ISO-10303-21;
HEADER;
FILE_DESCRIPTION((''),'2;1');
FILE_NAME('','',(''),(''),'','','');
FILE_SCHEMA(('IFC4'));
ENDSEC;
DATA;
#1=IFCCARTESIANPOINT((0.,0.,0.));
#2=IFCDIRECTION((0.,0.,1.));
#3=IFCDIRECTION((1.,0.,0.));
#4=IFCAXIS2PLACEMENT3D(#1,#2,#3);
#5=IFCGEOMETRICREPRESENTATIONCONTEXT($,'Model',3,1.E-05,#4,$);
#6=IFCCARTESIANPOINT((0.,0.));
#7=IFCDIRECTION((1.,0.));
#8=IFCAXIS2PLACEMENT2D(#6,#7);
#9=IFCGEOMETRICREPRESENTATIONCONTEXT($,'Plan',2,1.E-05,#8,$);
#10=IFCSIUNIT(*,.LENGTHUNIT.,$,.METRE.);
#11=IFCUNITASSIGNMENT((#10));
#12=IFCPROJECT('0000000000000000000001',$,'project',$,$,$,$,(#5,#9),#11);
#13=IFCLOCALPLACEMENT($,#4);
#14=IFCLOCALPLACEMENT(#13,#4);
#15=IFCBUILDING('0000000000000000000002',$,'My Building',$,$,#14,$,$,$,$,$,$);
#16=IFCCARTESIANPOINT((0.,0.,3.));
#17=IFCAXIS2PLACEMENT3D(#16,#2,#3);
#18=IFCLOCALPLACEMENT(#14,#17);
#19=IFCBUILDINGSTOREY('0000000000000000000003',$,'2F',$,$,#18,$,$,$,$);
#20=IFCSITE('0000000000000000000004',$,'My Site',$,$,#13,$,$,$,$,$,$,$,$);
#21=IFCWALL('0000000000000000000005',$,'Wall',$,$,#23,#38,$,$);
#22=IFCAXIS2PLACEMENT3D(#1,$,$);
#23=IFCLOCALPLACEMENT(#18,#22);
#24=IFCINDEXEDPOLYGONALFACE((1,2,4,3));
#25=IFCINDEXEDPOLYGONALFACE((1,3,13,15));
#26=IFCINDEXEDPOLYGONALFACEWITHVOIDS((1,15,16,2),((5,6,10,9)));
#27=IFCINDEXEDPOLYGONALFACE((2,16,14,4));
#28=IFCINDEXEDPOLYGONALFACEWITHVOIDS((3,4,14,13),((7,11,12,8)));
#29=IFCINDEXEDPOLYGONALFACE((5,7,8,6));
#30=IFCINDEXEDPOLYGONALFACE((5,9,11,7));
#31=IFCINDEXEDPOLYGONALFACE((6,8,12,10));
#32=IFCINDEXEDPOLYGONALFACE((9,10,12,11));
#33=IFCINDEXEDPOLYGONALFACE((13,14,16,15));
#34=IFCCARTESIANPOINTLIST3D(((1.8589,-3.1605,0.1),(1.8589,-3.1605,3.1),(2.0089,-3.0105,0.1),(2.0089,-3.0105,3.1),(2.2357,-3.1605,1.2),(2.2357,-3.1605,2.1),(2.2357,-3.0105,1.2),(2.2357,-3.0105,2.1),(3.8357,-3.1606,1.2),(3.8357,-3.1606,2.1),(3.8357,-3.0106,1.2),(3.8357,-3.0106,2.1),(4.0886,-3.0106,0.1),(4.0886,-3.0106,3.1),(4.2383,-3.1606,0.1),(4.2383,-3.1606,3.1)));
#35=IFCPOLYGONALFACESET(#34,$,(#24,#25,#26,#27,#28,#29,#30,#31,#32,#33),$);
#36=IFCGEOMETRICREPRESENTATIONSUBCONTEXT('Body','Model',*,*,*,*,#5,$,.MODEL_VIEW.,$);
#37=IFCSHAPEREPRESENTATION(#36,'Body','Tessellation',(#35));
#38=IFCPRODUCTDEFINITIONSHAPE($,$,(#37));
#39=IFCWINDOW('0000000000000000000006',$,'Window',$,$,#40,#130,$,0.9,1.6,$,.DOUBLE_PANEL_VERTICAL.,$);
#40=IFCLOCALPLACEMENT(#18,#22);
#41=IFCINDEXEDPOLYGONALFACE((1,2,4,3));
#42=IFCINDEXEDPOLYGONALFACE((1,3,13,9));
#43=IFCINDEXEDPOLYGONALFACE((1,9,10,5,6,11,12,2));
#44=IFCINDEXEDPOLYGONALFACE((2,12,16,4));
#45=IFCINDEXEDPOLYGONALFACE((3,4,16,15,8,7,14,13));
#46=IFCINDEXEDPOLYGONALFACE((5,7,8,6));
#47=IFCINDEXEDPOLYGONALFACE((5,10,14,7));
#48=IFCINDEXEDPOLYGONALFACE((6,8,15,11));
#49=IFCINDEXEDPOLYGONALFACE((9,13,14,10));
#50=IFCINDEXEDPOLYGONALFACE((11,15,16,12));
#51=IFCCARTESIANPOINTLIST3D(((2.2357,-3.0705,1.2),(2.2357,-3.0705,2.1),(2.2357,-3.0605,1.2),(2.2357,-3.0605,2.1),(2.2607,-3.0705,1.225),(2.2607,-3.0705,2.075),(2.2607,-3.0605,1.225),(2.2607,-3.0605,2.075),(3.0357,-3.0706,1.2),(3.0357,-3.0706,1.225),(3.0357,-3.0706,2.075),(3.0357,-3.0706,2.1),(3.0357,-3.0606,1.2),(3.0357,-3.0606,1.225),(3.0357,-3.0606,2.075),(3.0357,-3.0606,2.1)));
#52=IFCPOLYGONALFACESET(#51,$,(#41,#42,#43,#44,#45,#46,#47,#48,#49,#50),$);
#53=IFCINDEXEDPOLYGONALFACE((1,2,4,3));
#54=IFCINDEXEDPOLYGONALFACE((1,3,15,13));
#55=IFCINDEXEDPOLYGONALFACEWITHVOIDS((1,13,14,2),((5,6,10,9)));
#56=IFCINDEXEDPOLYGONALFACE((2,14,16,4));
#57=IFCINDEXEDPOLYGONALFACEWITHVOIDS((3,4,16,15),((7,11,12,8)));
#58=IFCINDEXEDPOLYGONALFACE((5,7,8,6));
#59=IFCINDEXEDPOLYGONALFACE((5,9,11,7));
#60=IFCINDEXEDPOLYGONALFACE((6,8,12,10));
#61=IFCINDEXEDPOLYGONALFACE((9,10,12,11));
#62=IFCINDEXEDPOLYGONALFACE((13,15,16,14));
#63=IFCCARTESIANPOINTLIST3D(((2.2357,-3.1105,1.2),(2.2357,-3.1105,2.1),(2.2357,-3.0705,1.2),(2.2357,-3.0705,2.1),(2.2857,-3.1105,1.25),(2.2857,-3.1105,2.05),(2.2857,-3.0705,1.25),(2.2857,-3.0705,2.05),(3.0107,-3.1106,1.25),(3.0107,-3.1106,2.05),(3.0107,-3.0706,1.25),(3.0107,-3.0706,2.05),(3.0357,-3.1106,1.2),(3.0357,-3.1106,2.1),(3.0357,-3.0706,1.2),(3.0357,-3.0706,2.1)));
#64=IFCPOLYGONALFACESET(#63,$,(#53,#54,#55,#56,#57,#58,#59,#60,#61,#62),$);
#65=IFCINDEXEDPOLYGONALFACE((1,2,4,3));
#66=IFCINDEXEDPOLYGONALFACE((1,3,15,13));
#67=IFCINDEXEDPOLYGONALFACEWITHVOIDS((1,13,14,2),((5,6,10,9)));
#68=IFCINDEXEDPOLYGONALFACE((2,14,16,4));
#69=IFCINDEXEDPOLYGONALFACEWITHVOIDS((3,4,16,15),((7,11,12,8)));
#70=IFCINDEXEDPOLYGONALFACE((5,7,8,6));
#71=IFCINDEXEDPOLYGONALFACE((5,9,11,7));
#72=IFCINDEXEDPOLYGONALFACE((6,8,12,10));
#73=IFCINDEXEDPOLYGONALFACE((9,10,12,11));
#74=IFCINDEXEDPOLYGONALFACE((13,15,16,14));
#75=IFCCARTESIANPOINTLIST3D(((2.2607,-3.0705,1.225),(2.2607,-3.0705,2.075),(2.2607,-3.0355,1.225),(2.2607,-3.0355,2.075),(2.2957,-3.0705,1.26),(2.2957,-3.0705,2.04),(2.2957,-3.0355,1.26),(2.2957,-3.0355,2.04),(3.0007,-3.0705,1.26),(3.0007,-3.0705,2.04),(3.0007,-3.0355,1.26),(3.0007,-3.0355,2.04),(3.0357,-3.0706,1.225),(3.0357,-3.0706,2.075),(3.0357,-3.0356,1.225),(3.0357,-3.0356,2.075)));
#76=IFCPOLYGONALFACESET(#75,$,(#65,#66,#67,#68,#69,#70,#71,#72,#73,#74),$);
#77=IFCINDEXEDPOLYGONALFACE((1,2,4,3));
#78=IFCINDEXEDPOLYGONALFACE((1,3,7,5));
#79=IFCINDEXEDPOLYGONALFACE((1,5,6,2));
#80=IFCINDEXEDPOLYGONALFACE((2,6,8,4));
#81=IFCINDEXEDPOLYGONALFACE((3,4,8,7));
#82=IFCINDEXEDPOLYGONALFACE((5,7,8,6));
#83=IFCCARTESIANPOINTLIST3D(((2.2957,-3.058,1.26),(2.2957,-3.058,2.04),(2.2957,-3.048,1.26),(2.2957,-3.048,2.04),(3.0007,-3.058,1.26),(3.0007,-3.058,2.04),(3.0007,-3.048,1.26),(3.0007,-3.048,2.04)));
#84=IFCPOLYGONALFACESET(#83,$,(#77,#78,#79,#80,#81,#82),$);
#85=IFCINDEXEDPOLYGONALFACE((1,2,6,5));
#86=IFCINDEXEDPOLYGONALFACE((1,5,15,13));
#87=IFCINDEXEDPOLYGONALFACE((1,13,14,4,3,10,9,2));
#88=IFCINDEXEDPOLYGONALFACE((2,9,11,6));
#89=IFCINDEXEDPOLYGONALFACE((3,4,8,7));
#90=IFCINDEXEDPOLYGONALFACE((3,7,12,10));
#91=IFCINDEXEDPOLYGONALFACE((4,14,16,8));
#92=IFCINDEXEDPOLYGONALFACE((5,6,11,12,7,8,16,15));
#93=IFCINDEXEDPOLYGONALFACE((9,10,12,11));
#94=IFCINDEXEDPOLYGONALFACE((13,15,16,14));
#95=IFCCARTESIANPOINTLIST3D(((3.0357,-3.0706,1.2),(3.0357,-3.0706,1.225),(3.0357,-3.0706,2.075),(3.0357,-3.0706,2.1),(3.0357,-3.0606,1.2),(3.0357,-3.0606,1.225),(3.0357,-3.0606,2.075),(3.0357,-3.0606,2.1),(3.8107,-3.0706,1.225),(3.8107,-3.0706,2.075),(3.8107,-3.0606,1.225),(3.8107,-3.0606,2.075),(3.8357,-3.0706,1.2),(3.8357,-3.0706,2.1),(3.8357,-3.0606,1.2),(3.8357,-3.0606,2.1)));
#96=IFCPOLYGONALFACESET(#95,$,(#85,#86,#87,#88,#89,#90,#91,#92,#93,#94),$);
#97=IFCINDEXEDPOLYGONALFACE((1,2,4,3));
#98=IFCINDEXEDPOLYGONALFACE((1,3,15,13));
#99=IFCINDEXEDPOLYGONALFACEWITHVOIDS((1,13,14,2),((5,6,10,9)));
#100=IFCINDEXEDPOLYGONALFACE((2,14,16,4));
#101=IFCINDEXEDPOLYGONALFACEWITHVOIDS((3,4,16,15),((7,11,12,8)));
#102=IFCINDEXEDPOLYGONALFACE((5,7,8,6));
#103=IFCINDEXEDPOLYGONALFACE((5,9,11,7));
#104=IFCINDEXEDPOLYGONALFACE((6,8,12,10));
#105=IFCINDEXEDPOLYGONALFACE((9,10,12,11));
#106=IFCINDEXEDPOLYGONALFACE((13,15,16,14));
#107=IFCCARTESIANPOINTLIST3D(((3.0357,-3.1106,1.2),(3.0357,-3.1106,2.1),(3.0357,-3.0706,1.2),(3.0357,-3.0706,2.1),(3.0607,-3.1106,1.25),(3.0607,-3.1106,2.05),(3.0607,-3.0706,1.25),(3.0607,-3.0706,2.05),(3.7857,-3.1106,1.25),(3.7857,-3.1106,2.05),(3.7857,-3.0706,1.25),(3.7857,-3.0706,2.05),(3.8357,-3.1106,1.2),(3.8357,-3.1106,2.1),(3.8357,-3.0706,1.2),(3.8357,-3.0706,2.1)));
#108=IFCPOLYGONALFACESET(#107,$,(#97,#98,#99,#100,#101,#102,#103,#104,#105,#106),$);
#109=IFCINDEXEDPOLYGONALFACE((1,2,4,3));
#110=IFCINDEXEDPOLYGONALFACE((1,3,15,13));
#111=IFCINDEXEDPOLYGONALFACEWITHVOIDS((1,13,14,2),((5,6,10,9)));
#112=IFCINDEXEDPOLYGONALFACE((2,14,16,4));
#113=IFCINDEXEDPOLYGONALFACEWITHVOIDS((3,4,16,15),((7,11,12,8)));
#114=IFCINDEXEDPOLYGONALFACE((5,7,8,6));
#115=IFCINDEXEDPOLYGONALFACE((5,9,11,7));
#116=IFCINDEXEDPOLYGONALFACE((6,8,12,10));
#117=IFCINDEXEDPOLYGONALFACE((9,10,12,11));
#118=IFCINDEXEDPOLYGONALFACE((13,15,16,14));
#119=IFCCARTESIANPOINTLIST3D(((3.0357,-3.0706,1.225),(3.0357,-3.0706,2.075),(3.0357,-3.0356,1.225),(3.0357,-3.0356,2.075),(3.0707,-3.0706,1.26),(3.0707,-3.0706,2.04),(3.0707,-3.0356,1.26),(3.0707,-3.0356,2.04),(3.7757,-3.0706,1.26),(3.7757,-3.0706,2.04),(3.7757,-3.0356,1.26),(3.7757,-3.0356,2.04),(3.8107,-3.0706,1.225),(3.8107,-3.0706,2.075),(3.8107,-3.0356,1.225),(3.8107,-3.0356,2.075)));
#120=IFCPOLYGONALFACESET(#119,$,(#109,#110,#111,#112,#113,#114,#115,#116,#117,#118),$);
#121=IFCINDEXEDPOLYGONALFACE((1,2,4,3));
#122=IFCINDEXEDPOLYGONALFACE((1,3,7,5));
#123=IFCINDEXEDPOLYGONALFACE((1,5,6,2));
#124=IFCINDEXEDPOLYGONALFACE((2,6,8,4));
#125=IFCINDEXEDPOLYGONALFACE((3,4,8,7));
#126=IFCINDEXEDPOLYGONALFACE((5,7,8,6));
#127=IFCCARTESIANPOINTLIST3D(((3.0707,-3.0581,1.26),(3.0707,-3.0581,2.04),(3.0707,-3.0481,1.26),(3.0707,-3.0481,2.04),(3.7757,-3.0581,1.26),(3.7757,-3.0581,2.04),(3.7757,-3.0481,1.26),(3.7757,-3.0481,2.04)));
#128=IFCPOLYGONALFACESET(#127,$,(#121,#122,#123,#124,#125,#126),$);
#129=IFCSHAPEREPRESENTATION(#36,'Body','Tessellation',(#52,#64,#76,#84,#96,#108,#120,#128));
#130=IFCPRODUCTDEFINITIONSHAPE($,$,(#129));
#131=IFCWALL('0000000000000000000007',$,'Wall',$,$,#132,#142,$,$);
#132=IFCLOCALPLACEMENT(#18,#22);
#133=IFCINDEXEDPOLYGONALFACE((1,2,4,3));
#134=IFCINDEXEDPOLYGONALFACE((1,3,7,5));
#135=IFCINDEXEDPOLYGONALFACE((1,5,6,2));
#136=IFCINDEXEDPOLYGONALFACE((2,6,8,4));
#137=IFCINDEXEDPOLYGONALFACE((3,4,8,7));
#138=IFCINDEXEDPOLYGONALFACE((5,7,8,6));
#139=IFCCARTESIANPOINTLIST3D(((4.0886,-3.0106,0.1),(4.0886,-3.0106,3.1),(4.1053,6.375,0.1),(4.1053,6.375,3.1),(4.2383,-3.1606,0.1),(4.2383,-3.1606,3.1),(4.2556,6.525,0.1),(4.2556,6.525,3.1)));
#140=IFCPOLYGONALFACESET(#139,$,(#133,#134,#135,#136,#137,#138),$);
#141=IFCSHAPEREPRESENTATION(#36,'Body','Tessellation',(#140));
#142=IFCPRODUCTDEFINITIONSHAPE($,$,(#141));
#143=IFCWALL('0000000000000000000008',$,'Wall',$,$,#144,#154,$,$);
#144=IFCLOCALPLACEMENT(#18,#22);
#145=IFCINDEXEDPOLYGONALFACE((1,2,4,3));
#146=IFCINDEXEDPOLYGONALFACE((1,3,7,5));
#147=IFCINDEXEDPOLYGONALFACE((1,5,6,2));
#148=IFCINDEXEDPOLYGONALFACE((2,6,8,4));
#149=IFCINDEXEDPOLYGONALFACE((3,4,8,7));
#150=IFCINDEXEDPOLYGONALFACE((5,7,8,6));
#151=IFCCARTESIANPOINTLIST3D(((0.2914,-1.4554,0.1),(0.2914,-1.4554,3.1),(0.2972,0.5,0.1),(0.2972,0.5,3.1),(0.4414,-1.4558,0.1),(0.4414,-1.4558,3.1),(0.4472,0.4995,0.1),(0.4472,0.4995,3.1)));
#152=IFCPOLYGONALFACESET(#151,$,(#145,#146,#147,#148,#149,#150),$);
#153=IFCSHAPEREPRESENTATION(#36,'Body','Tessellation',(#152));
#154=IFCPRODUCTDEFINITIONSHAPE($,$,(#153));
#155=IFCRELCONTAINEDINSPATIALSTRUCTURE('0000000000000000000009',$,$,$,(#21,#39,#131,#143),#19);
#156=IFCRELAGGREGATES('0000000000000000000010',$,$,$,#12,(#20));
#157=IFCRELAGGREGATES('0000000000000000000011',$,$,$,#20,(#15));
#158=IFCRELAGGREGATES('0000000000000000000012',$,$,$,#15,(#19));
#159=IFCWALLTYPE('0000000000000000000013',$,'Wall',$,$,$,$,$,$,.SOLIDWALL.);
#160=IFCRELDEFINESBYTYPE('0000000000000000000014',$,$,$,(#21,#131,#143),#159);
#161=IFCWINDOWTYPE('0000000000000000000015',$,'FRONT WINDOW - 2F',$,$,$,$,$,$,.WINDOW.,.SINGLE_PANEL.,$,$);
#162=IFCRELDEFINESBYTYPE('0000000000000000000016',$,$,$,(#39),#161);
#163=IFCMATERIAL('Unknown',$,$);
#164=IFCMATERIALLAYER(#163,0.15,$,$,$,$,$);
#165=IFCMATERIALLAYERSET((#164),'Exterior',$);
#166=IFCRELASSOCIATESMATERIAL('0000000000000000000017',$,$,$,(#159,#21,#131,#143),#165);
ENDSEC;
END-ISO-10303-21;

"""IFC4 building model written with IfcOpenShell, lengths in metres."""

from ifc_helpers import new_model, entity, si_unit, frame, origin_with_axes, origin_2d_with_axis, place, context, subcontext, project, spatial, line, indexed_curve, outline, extrude, shape, source, transform, mapped, material, layer, layer_set, layer_usage, type_object, type_shapes, element, fill, save


model = new_model("IFC4")

# Units and contexts
model_context = context("Model", 3, precision=1e-05, world=origin_with_axes())
plan_context = context("Plan", 2, precision=1e-05, world=origin_2d_with_axis())
body_context_1 = subcontext(model_context, "Body", "Model", "MODEL_VIEW")
body_context_2 = subcontext(plan_context, "Body", "Plan", "PLAN_VIEW")
ifc_project = project(units=[si_unit("LENGTHUNIT", "METRE")], contexts=[model_context, plan_context])

# Site, building, storey
site_placement = place(None, origin_with_axes())
site = spatial("IfcSite", under=ifc_project, at=site_placement, Name="My Site")
building_placement = place(site_placement, origin_with_axes())
building = spatial("IfcBuilding", under=site, at=building_placement, Name="My Building")
storey_placement = place(building_placement, frame((0.0, 0.0, 3.0), z_axis=(0.0, 0.0, 1.0), x_axis=(1.0, 0.0, 0.0)))
storey = spatial("IfcBuildingStorey", under=building, at=storey_placement, Name="2F")

# Shared definitions
ifc_material = material(Name="Unknown")

# Shared definitions
ifc_layer_1 = layer(ifc_material, 0.15)
ifc_layer_set_1 = layer_set([ifc_layer_1], Name="Exterior")
wall_type_1 = type_object("IfcWallType", Name="Wall", PredefinedType="SOLIDWALL", material=ifc_layer_set_1)

# Wall, opening, window
ifc_layer_usage_1 = layer_usage(ifc_layer_set_1, "AXIS2", "POSITIVE", 0.0)
wall_1_placement = place(storey_placement, frame((1.8589, -3.1605, 0.1), z_axis=(0.0, 0.0, 1.0), x_axis=(1.0, -0.000063, 0.0)))
wall_1 = element("IfcWall", 1, at=wall_1_placement, inside=storey, type_object=wall_type_1, material=ifc_layer_usage_1, Name="Wall", context=body_context_1, shape_type="SweptSolid", body=[
    extrude(outline(indexed_curve([(0.0, 0.0), (0.15, 0.15), (2.2297, 0.15), (2.3795, 0.0)], segments=[line(1, 2, 3, 4, 1)])), origin_with_axes(), (0.0, 0.0, 1.0), 3.0),
])
shared_shape_1 = source(origin_with_axes(), body_context_1, "Body", "SweptSolid", [
    extrude(outline(indexed_curve([(0.0, 0.0), (1.6, 0.0), (1.6, 0.9), (0.0, 0.9)], segments=[line(1, 2, 3, 4, 1)])), frame((0.0, -0.6, 0.0), z_axis=(0.0, -1.0, 0.0), x_axis=(1.0, 0.0, 0.0)), (0.0, 0.0, -1.0), 1.2),
])
opening_1_placement = place(wall_1_placement, frame((0.3769, 0.0, 1.1), z_axis=(0.0, 0.0, 1.0), x_axis=(1.0, 0.0, 0.0)))
opening_1 = element("IfcOpeningElement", 2, at=opening_1_placement, cuts=wall_1, PredefinedType="OPENING", context=body_context_1, shape_type="MappedRepresentation", body=[
    mapped(shared_shape_1, transform((0.0, 0.0, 0.0), x_axis=(1.0, 0.0, 0.0), y_axis=(0.0, 1.0, 0.0), z_axis=(0.0, 0.0, 1.0), scale=1.0)),
])
window_type_1 = type_object("IfcWindowType", Name="FRONT WINDOW - 2F", PartitioningType="SINGLE_PANEL", PredefinedType="WINDOW")
shared_shape_2 = source(origin_with_axes(), body_context_1, "Body", "SweptSolid", [
    extrude(outline(indexed_curve([(0.8, 0.0), (0.0, 0.0), (0.0, 0.9), (0.8, 0.9), (0.8, 0.875), (0.025, 0.875), (0.025, 0.025), (0.8, 0.025)], segments=[line(1, 2, 3, 4, 5, 6, 7, 8, 1)])), frame((0.0, 0.09, 0.0), z_axis=(0.0, -1.0, 0.0), x_axis=(1.0, 0.0, 0.0)), (0.0, 0.0, -1.0), 0.01),
    extrude(outline(indexed_curve([(0.0, 0.0), (0.8, 0.0), (0.8, 0.9), (0.0, 0.9)], segments=[line(1, 2, 3, 4, 1)]), holes=[indexed_curve([(0.05, 0.05), (0.775, 0.05), (0.775, 0.85), (0.05, 0.85)], segments=[line(1, 2, 3, 4, 1)])]), frame((0.0, 0.05, 0.0), z_axis=(0.0, -1.0, 0.0), x_axis=(1.0, 0.0, 0.0)), (0.0, 0.0, -1.0), 0.04),
    extrude(outline(indexed_curve([(0.0, 0.0), (0.775, 0.0), (0.775, 0.85), (0.0, 0.85)], segments=[line(1, 2, 3, 4, 1)]), holes=[indexed_curve([(0.035, 0.035), (0.74, 0.035), (0.74, 0.815), (0.035, 0.815)], segments=[line(1, 2, 3, 4, 1)])]), frame((0.025, 0.09, 0.025), z_axis=(0.0, -1.0, 0.0), x_axis=(1.0, 0.0, 0.0)), (0.0, 0.0, -1.0), 0.035),
    extrude(outline(indexed_curve([(0.035, 0.035), (0.74, 0.035), (0.74, 0.815), (0.035, 0.815)], segments=[line(1, 2, 3, 4, 1)])), frame((0.025, 0.1025, 0.025), z_axis=(0.0, -1.0, 0.0), x_axis=(1.0, 0.0, 0.0)), (0.0, 0.0, -1.0), 0.01),
    extrude(outline(indexed_curve([(0.0, 0.9), (0.8, 0.9), (0.8, 0.0), (0.0, 0.0), (0.0, 0.025), (0.775, 0.025), (0.775, 0.875), (0.0, 0.875)], segments=[line(1, 2, 3, 4, 5, 6, 7, 8, 1)])), frame((0.8, 0.09, 0.0), z_axis=(0.0, -1.0, 0.0), x_axis=(1.0, 0.0, 0.0)), (0.0, 0.0, -1.0), 0.01),
    extrude(outline(indexed_curve([(0.0, 0.0), (0.8, 0.0), (0.8, 0.9), (0.0, 0.9)], segments=[line(1, 2, 3, 4, 1)]), holes=[indexed_curve([(0.025, 0.05), (0.75, 0.05), (0.75, 0.85), (0.025, 0.85)], segments=[line(1, 2, 3, 4, 1)])]), frame((0.8, 0.05, 0.0), z_axis=(0.0, -1.0, 0.0), x_axis=(1.0, 0.0, 0.0)), (0.0, 0.0, -1.0), 0.04),
    extrude(outline(indexed_curve([(0.0, 0.0), (0.775, 0.0), (0.775, 0.85), (0.0, 0.85)], segments=[line(1, 2, 3, 4, 1)]), holes=[indexed_curve([(0.035, 0.035), (0.74, 0.035), (0.74, 0.815), (0.035, 0.815)], segments=[line(1, 2, 3, 4, 1)])]), frame((0.8, 0.09, 0.025), z_axis=(0.0, -1.0, 0.0), x_axis=(1.0, 0.0, 0.0)), (0.0, 0.0, -1.0), 0.035),
    extrude(outline(indexed_curve([(0.035, 0.035), (0.74, 0.035), (0.74, 0.815), (0.035, 0.815)], segments=[line(1, 2, 3, 4, 1)])), frame((0.8, 0.1025, 0.025), z_axis=(0.0, -1.0, 0.0), x_axis=(1.0, 0.0, 0.0)), (0.0, 0.0, -1.0), 0.01),
])
shared_shape_3 = source(origin_with_axes(), body_context_2, "Body", "Curve2D", [
    entity("IfcIndexedPolyCurve", entity("IfcCartesianPointList2D", [[0.05, 0.05], [0.775, 0.05]])),
    entity("IfcIndexedPolyCurve", entity("IfcCartesianPointList2D", [[0.0, 0.1], [0.025, 0.1], [0.025, 0.09], [0.05, 0.09], [0.05, 0.05], [0.0, 0.05]]), [entity("IfcLineIndex", [1, 2, 3, 4, 5, 6, 1])]),
    entity("IfcIndexedPolyCurve", entity("IfcCartesianPointList2D", [[0.8, 0.1], [0.8, 0.1], [0.8, 0.09], [0.775, 0.09], [0.775, 0.05], [0.8, 0.05]])),
    entity("IfcIndexedPolyCurve", entity("IfcCartesianPointList2D", [[0.025, 0.09], [0.06, 0.09], [0.06, 0.125], [0.025, 0.125]]), [entity("IfcLineIndex", [1, 2, 3, 4, 1])]),
    entity("IfcIndexedPolyCurve", entity("IfcCartesianPointList2D", [[0.8, 0.09], [0.765, 0.09], [0.765, 0.125], [0.8, 0.125]]), [entity("IfcLineIndex", [1, 2, 3, 4, 1])]),
    entity("IfcIndexedPolyCurve", entity("IfcCartesianPointList2D", [[0.06, 0.09], [0.765, 0.09]])),
    entity("IfcIndexedPolyCurve", entity("IfcCartesianPointList2D", [[0.06, 0.125], [0.765, 0.125]])),
    entity("IfcIndexedPolyCurve", entity("IfcCartesianPointList2D", [[0.06, 0.1075], [0.765, 0.1075]])),
    entity("IfcIndexedPolyCurve", entity("IfcCartesianPointList2D", [[0.825, 0.05], [1.55, 0.05]])),
    entity("IfcIndexedPolyCurve", entity("IfcCartesianPointList2D", [[0.8, 0.1], [0.8, 0.1], [0.8, 0.09], [0.825, 0.09], [0.825, 0.05], [0.8, 0.05]])),
    entity("IfcIndexedPolyCurve", entity("IfcCartesianPointList2D", [[1.6, 0.1], [1.575, 0.1], [1.575, 0.09], [1.55, 0.09], [1.55, 0.05], [1.6, 0.05]]), [entity("IfcLineIndex", [1, 2, 3, 4, 5, 6, 1])]),
    entity("IfcIndexedPolyCurve", entity("IfcCartesianPointList2D", [[0.8, 0.09], [0.835, 0.09], [0.835, 0.125], [0.8, 0.125]]), [entity("IfcLineIndex", [1, 2, 3, 4, 1])]),
    entity("IfcIndexedPolyCurve", entity("IfcCartesianPointList2D", [[1.575, 0.09], [1.54, 0.09], [1.54, 0.125], [1.575, 0.125]]), [entity("IfcLineIndex", [1, 2, 3, 4, 1])]),
    entity("IfcIndexedPolyCurve", entity("IfcCartesianPointList2D", [[0.835, 0.09], [1.54, 0.09]])),
    entity("IfcIndexedPolyCurve", entity("IfcCartesianPointList2D", [[0.835, 0.125], [1.54, 0.125]])),
    entity("IfcIndexedPolyCurve", entity("IfcCartesianPointList2D", [[0.835, 0.1075], [1.54, 0.1075]])),
])
type_shapes(window_type_1, [shared_shape_2, shared_shape_3])
window_1_placement = place(opening_1_placement, origin_with_axes())
window_1 = element("IfcWindow", 3, at=window_1_placement, inside=storey, type_object=window_type_1, Name="Window", OverallHeight=0.9, OverallWidth=1.6, PartitioningType="DOUBLE_PANEL_VERTICAL", shapes=[
    shape(body_context_1, "Body", "MappedRepresentation", [mapped(shared_shape_2, transform((0.0, 0.0, 0.0), x_axis=(1.0, 0.0, 0.0), y_axis=(0.0, 1.0, 0.0), z_axis=(0.0, 0.0, 1.0), scale=1.0))]),
    shape(body_context_2, "Body", "MappedRepresentation", [mapped(shared_shape_3, transform((0.0, 0.0, 0.0), x_axis=(1.0, 0.0, 0.0), y_axis=(0.0, 1.0, 0.0), z_axis=(0.0, 0.0, 1.0), scale=1.0))]),
])
fill(opening_1, window_1)

# Walls
ifc_layer_usage_2 = layer_usage(ifc_layer_set_1, "AXIS2", "POSITIVE", 0.0)
wall_2_placement = place(storey_placement, frame((4.2383, -3.1606, 0.1), z_axis=(0.0, 0.0, 1.0), x_axis=(0.001781, 0.999998, 0.0)))
element("IfcWall", 4, at=wall_2_placement, inside=storey, type_object=wall_type_1, material=ifc_layer_usage_2, Name="Wall", context=body_context_1, shape_type="SweptSolid", body=[
    extrude(outline(indexed_curve([(0.0, 0.0), (0.1497, 0.15), (9.5354, 0.15), (9.6856, 0.0)], segments=[line(1, 2, 3, 4, 1)])), origin_with_axes(), (0.0, 0.0, 1.0), 3.0),
])
ifc_layer_usage_3 = layer_usage(ifc_layer_set_1, "AXIS2", "POSITIVE", 0.0)
wall_3_placement = place(storey_placement, frame((0.2972, 0.5, 0.1), z_axis=(0.0, 0.0, 1.0), x_axis=(-0.00298, -0.999996, 0.0)))
element("IfcWall", 5, at=wall_3_placement, inside=storey, type_object=wall_type_1, material=ifc_layer_usage_3, Name="Wall", context=body_context_1, shape_type="SweptSolid", body=[
    extrude(outline(indexed_curve([(0.0, 0.0), (0.0, 0.15), (1.9554, 0.15), (1.9554, 0.0)], segments=[line(1, 2, 3, 4, 1)])), origin_with_axes(), (0.0, 0.0, 1.0), 3.0),
])

save(model, "model.ifc")
